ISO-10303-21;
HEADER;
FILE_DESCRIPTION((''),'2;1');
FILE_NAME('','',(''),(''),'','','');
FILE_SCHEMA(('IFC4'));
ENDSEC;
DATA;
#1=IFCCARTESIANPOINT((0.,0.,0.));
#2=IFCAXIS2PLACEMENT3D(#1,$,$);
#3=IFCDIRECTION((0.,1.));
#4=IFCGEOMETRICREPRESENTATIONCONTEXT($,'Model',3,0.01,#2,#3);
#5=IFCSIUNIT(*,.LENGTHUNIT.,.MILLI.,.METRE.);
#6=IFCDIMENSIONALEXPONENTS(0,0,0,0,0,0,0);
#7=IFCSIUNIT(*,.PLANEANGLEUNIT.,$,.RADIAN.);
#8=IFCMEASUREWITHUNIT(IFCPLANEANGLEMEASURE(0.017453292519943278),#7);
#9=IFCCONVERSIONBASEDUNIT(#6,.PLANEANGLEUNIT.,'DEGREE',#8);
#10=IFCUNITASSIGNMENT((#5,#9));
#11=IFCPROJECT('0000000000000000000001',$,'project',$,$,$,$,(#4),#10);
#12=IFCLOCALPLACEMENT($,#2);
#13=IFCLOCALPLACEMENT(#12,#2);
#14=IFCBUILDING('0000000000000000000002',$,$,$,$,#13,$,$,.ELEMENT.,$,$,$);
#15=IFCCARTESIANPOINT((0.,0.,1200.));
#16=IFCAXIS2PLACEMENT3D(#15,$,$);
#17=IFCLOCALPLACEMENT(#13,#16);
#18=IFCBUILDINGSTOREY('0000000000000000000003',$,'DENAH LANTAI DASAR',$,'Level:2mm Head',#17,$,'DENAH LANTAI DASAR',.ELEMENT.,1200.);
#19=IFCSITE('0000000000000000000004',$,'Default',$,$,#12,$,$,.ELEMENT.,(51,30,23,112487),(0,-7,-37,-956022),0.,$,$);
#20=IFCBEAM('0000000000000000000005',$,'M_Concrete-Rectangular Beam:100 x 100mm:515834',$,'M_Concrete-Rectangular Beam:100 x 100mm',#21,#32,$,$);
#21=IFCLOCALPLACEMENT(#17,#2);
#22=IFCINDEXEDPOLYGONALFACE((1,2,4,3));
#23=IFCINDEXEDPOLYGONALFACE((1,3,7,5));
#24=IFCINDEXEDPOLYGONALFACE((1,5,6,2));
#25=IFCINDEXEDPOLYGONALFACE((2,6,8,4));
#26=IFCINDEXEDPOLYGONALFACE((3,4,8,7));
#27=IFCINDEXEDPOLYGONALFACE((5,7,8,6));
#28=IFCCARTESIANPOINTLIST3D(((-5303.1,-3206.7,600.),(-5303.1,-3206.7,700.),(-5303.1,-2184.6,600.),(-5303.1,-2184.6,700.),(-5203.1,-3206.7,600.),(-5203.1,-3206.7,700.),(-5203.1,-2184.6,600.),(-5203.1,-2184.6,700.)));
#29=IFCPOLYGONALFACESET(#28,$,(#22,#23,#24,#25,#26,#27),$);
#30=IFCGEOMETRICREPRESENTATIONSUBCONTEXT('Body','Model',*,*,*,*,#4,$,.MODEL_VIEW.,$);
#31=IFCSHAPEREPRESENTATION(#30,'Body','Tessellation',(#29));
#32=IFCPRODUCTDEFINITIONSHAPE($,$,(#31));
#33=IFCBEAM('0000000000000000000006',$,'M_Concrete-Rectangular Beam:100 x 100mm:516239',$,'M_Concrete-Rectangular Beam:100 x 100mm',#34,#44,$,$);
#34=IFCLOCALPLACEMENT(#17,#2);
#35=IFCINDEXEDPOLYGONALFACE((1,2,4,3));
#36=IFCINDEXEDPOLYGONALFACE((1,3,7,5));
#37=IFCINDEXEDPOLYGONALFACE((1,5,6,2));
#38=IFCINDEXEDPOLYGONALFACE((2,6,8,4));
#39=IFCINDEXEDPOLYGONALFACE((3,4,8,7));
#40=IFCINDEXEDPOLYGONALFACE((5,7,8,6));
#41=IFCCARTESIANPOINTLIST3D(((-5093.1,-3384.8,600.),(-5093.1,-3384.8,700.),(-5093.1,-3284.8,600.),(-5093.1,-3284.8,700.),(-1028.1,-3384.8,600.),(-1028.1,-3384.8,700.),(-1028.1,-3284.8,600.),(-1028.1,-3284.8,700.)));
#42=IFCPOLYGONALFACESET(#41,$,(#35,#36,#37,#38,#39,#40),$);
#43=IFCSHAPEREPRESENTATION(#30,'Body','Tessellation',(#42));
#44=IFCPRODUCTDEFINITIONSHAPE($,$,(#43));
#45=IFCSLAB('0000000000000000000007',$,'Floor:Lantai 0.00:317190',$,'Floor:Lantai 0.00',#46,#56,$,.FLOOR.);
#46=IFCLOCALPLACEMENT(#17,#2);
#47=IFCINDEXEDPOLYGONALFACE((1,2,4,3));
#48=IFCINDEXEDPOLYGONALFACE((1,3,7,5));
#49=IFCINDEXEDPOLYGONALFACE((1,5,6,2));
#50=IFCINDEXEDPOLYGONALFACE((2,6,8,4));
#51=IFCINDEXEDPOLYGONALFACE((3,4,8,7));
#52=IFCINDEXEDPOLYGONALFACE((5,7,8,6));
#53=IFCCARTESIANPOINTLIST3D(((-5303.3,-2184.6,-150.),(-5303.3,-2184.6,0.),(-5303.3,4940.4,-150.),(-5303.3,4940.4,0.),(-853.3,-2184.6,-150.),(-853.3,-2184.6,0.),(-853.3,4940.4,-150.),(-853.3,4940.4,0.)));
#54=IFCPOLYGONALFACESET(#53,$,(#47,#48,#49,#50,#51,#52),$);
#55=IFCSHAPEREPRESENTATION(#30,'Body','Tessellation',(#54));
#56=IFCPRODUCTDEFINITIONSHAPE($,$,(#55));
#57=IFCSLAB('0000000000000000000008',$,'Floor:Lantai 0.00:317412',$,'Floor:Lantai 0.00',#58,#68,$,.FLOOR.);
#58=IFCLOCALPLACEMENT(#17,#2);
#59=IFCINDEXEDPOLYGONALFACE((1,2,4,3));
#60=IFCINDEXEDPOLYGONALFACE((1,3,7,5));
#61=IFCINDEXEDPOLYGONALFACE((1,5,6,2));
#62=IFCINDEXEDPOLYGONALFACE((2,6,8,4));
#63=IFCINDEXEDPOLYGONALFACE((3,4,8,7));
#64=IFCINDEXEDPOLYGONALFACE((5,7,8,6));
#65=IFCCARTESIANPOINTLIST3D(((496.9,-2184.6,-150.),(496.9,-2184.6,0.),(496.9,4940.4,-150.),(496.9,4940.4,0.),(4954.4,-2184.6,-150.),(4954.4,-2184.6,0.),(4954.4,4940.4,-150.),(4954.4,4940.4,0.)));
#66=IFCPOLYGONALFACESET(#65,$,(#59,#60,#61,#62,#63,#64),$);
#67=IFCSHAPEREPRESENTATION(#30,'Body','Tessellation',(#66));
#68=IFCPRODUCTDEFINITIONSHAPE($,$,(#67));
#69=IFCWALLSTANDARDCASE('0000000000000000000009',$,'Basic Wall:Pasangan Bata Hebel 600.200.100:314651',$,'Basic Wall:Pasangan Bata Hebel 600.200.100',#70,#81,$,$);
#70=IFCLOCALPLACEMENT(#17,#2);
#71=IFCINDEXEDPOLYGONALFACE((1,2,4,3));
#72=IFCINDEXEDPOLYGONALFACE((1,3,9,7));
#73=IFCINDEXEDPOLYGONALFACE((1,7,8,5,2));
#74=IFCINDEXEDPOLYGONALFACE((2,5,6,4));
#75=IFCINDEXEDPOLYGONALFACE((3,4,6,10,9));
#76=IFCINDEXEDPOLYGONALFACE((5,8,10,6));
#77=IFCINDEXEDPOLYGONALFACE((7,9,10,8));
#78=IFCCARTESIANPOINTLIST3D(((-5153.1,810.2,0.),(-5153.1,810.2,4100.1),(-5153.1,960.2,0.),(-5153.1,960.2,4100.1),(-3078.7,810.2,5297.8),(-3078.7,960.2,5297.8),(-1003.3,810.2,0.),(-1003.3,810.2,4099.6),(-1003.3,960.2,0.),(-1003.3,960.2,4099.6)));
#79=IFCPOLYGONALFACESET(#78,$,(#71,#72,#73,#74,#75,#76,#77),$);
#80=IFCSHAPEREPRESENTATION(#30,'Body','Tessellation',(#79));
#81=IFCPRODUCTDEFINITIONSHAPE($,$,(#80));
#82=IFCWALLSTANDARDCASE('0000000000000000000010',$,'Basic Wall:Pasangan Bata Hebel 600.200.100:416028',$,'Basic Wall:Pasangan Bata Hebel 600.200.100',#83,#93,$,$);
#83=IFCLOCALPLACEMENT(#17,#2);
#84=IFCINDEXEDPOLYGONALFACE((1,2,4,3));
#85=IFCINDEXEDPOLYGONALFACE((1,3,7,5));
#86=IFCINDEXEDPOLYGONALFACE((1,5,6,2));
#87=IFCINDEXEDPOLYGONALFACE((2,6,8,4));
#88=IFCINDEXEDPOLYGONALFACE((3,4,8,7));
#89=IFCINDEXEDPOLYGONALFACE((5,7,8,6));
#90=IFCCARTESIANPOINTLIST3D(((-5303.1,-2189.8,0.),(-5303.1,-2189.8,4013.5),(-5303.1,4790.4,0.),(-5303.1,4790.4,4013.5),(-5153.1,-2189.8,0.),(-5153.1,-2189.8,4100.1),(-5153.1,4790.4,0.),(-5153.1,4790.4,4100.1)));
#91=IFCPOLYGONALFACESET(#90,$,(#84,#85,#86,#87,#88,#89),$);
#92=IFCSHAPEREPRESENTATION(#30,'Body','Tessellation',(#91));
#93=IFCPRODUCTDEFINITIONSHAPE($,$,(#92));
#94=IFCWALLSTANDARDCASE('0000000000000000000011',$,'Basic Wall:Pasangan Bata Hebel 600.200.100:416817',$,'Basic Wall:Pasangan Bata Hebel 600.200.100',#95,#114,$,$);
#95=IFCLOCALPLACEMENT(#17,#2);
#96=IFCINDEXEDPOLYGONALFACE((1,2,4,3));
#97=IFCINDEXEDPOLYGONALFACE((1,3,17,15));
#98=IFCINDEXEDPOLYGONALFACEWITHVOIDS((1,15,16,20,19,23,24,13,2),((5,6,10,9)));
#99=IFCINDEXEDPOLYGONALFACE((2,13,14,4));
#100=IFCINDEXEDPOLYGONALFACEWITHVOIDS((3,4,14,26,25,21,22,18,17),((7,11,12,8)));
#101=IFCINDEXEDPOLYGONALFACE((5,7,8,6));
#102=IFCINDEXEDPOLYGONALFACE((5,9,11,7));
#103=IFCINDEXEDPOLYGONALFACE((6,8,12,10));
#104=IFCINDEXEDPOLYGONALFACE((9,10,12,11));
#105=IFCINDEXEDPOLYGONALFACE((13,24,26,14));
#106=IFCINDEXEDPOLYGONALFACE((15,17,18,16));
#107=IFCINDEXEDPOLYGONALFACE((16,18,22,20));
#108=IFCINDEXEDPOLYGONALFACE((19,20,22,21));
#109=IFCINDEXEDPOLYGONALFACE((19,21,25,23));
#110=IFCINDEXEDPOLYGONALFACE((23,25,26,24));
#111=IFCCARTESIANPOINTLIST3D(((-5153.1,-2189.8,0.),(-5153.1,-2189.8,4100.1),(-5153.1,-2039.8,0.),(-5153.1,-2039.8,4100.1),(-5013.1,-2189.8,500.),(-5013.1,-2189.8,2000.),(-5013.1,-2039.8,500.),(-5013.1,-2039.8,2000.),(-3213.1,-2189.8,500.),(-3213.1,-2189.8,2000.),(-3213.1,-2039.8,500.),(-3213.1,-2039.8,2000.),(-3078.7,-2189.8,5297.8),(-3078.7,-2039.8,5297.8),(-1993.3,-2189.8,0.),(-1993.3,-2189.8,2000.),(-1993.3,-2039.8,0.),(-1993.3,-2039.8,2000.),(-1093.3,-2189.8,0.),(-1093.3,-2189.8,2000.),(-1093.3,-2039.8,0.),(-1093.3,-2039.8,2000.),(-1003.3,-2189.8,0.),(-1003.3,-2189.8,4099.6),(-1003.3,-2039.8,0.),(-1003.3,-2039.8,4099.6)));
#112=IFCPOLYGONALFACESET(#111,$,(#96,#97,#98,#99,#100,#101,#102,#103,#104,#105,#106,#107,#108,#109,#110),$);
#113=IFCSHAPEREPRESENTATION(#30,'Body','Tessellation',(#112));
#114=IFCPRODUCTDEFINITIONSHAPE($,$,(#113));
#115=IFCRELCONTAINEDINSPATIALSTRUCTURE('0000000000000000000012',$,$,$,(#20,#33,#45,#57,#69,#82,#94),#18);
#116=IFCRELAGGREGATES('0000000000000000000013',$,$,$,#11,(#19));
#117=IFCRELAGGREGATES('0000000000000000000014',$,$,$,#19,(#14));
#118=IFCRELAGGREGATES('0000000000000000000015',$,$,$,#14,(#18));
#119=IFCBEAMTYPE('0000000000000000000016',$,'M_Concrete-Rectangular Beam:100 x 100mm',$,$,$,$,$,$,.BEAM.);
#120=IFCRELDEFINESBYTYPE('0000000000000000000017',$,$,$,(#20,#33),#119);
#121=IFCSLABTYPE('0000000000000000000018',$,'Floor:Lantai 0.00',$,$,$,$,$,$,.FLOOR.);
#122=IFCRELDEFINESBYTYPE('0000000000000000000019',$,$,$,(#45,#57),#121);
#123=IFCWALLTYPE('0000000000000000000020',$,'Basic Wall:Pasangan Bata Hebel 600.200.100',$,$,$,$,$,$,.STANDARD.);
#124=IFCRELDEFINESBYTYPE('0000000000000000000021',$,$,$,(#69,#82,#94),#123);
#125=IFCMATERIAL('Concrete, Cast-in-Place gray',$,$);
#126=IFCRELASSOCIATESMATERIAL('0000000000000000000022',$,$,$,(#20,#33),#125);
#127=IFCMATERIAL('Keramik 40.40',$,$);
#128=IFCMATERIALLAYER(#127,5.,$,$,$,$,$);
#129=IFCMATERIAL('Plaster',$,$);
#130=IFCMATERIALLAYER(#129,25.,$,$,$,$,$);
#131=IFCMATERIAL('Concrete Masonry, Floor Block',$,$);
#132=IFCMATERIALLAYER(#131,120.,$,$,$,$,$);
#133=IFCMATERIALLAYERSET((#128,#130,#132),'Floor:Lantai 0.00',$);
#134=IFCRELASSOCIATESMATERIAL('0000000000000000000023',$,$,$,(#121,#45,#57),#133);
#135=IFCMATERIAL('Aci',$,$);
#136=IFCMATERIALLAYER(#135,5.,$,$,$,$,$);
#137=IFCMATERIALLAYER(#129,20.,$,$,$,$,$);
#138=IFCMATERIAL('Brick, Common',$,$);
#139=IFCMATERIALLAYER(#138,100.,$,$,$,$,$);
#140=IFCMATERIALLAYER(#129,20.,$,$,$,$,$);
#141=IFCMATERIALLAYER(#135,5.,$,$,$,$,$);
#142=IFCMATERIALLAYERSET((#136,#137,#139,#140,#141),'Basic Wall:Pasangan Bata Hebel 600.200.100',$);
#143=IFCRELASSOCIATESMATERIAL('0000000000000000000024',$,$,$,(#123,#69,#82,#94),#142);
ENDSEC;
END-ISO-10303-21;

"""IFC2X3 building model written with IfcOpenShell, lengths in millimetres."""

from ifc_helpers import new_model, entity, si_unit, converted_unit, direction, frame, frame_2d, origin, origin_2d_with_axis, place, context, subcontext, project, spatial, polyline, rectangle, extrude, clip, bounded_halfspace, material, layer, layer_set, layer_usage, type_object, element, save


model = new_model("IFC2X3")

# Units and contexts
model_context = context("Model", 3, precision=0.01, world=origin(), true_north=direction((0.0, 1.0)))
body_context = subcontext(model_context, "Body", "Model", "MODEL_VIEW")
ifc_project = project(units=[si_unit("LENGTHUNIT", "METRE", prefix="MILLI"), converted_unit("PLANEANGLEUNIT", "DEGREE", entity("IfcPlaneAngleMeasure", 0.017453292519943278), si_unit("PLANEANGLEUNIT", "RADIAN"), dimensions=[0, 0, 0, 0, 0, 0, 0])], contexts=[model_context])

# Site, building, storey
site_placement = place(None, origin())
site = spatial("IfcSite", under=ifc_project, at=site_placement, Name="Default", CompositionType="ELEMENT", RefLatitude=(51, 30, 23, 112487), RefLongitude=(0, -7, -37, -956022), RefElevation=0.0)
building_placement = place(site_placement, origin())
building = spatial("IfcBuilding", under=site, at=building_placement, CompositionType="ELEMENT")
storey_placement = place(building_placement, frame((0.0, 0.0, 1200.0)))
storey = spatial("IfcBuildingStorey", under=building, at=storey_placement, Name="DENAH LANTAI DASAR", ObjectType="Level:2mm Head", LongName="DENAH LANTAI DASAR", CompositionType="ELEMENT", Elevation=1200.0)

# Shared definitions
ifc_material_1 = material(Name="Concrete, Cast-in-Place gray")

# Beams
beam_type = type_object("IfcBeamType", Name="M_Concrete-Rectangular Beam:100 x 100mm", PredefinedType="BEAM")
beam_1_placement = place(storey_placement, frame((-5253.1, -2184.6, 700.0), z_axis=(0.0, 0.0, 1.0), x_axis=(0.0, -1.0, 0.0)))
element("IfcBeam", 1, at=beam_1_placement, inside=storey, type_object=beam_type, material=ifc_material_1, Name="M_Concrete-Rectangular Beam:100 x 100mm:515834", ObjectType="M_Concrete-Rectangular Beam:100 x 100mm", context=body_context, shape_type="SweptSolid", body=[
    extrude(rectangle(XDim=100.0, YDim=100.0, at=frame_2d((0.0, 0.0), x_axis=(1.0, 0.0))), frame((0.0, 0.0, -50.0), z_axis=(1.0, 0.0, 0.0), x_axis=(0.0, 0.0, -1.0)), (0.0, 0.0, 1.0), 1022.1),
])
beam_2_placement = place(storey_placement, frame((-5093.1, -3334.8, 700.0)))
element("IfcBeam", 2, at=beam_2_placement, inside=storey, type_object=beam_type, material=ifc_material_1, Name="M_Concrete-Rectangular Beam:100 x 100mm:516239", ObjectType="M_Concrete-Rectangular Beam:100 x 100mm", context=body_context, shape_type="SweptSolid", body=[
    extrude(rectangle(XDim=100.0, YDim=100.0, at=origin_2d_with_axis()), frame((0.0, 0.0, -50.0), z_axis=(1.0, 0.0, 0.0), x_axis=(0.0, 0.0, -1.0)), (0.0, 0.0, 1.0), 4065.0),
])

# Slabs
ifc_material_2 = material(Name="Keramik 40.40")
ifc_layer_1 = layer(ifc_material_2, 5.0)
ifc_material_3 = material(Name="Plaster")
ifc_layer_2 = layer(ifc_material_3, 25.0)
ifc_material_4 = material(Name="Concrete Masonry, Floor Block")
ifc_layer_3 = layer(ifc_material_4, 120.0)
ifc_layer_set_1 = layer_set([ifc_layer_1, ifc_layer_2, ifc_layer_3], Name="Floor:Lantai 0.00")
ifc_layer_usage_1 = layer_usage(ifc_layer_set_1, "AXIS3", "POSITIVE", 0.0)
slab_type_1 = type_object("IfcSlabType", Name="Floor:Lantai 0.00", PredefinedType="FLOOR", material=ifc_layer_set_1)
slab_1_placement = place(storey_placement, origin())
element("IfcSlab", 3, at=slab_1_placement, inside=storey, type_object=slab_type_1, material=ifc_layer_usage_1, Name="Floor:Lantai 0.00:317190", ObjectType="Floor:Lantai 0.00", PredefinedType="FLOOR", context=body_context, shape_type="SweptSolid", body=[
    extrude(rectangle(XDim=7125.0, YDim=4450.0, at=origin_2d_with_axis()), frame((-3078.3, 1377.9, 0.0), z_axis=(0.0, 0.0, -1.0), x_axis=(0.0, 1.0, 0.0)), (0.0, 0.0, 1.0), 150.0),
])
ifc_layer_usage_2 = layer_usage(ifc_layer_set_1, "AXIS3", "POSITIVE", 0.0)
slab_2_placement = place(storey_placement, origin())
element("IfcSlab", 4, at=slab_2_placement, inside=storey, type_object=slab_type_1, material=ifc_layer_usage_2, Name="Floor:Lantai 0.00:317412", ObjectType="Floor:Lantai 0.00", PredefinedType="FLOOR", context=body_context, shape_type="SweptSolid", body=[
    extrude(rectangle(XDim=7125.0, YDim=4457.5, at=frame_2d((0.0, 0.0), x_axis=(1.0, 0.0))), frame((2725.7, 1377.9, 0.0), z_axis=(0.0, 0.0, -1.0), x_axis=(0.0, 1.0, 0.0)), (0.0, 0.0, 1.0), 150.0),
])

# Walls
ifc_material_5 = material(Name="Aci")
ifc_layer_4 = layer(ifc_material_5, 5.0)
ifc_layer_5 = layer(ifc_material_3, 20.0)
ifc_material_6 = material(Name="Brick, Common")
ifc_layer_6 = layer(ifc_material_6, 100.0)
ifc_layer_7 = layer(ifc_material_3, 20.0)
ifc_layer_8 = layer(ifc_material_5, 5.0)
ifc_layer_set_2 = layer_set([ifc_layer_4, ifc_layer_5, ifc_layer_6, ifc_layer_7, ifc_layer_8], Name="Basic Wall:Pasangan Bata Hebel 600.200.100")
ifc_layer_usage_3 = layer_usage(ifc_layer_set_2, "AXIS2", "NEGATIVE", 75.0)
wall_type = type_object("IfcWallType", Name="Basic Wall:Pasangan Bata Hebel 600.200.100", PredefinedType="STANDARD", material=ifc_layer_set_2)
wall_1_placement = place(storey_placement, frame((-1003.3, 885.2, 0.0), z_axis=(0.0, 0.0, 1.0), x_axis=(-1.0, 0.0, 0.0)))
element("IfcWallStandardCase", 5, at=wall_1_placement, inside=storey, type_object=wall_type, material=ifc_layer_usage_3, Name="Basic Wall:Pasangan Bata Hebel 600.200.100:314651", ObjectType="Basic Wall:Pasangan Bata Hebel 600.200.100", context=body_context, shape_type="Clipping", body=[
    clip(clip(extrude(rectangle(XDim=4149.8, YDim=150.0, at=frame_2d((2074.9, 0.0), x_axis=(-1.0, 0.0))), origin(), (0.0, 0.0, 1.0), 5297.8), bounded_halfspace(frame((2075.4, -75.0, 5297.8), z_axis=(0.5, 0.0, 0.866025), x_axis=(0.0, 1.0, 0.0)), False, frame((2075.4, -75.0, 5297.8)), polyline([(0.0, 0.0), (2074.4, 0.0), (2074.4, 150.0), (0.0, 150.0), (0.0, 0.0)]))), bounded_halfspace(frame((0.0, -75.0, 4099.6), z_axis=(-0.5, 0.0, 0.866025), x_axis=(0.0, -1.0, 0.0)), False, frame((0.0, -75.0, 4099.6)), polyline([(0.0, 0.0), (2075.4, 0.0), (2075.4, 150.0), (0.0, 150.0), (0.0, 0.0)]))),
])
ifc_layer_usage_4 = layer_usage(ifc_layer_set_2, "AXIS2", "NEGATIVE", 75.0)
wall_2_placement = place(storey_placement, frame((-5228.1, -2189.8, 0.0), z_axis=(0.0, 0.0, 1.0), x_axis=(0.0, 1.0, 0.0)))
element("IfcWallStandardCase", 6, at=wall_2_placement, inside=storey, type_object=wall_type, material=ifc_layer_usage_4, Name="Basic Wall:Pasangan Bata Hebel 600.200.100:416028", ObjectType="Basic Wall:Pasangan Bata Hebel 600.200.100", context=body_context, shape_type="Clipping", body=[
    clip(extrude(rectangle(XDim=6980.2, YDim=150.0, at=frame_2d((3490.1, 0.0), x_axis=(-1.0, 0.0))), origin(), (0.0, 0.0, 1.0), 4100.1), bounded_halfspace(frame((0.0, -75.0, 4100.1), z_axis=(0.0, 0.5, 0.866025), x_axis=(-1.0, 0.0, 0.0)), False, frame((0.0, -75.0, 4100.1)), polyline([(0.0, 0.0), (150.0, 0.0), (3000.0, 0.0), (3150.0, 0.0), (6980.2, 0.0), (6980.2, 150.0), (0.0, 150.0), (0.0, 0.0)]))),
])

# Wall, openings
ifc_layer_usage_5 = layer_usage(ifc_layer_set_2, "AXIS2", "NEGATIVE", 75.0)
wall_3_placement = place(storey_placement, frame((-5153.1, -2114.8, 0.0)))
wall_3 = element("IfcWallStandardCase", 7, at=wall_3_placement, inside=storey, type_object=wall_type, material=ifc_layer_usage_5, Name="Basic Wall:Pasangan Bata Hebel 600.200.100:416817", ObjectType="Basic Wall:Pasangan Bata Hebel 600.200.100", context=body_context, shape_type="Clipping", body=[
    clip(clip(extrude(rectangle(XDim=4149.8, YDim=150.0, at=frame_2d((2074.9, 0.0), x_axis=(-1.0, 0.0))), origin(), (0.0, 0.0, 1.0), 5297.8), bounded_halfspace(frame((0.0, -75.0, 4100.1), z_axis=(-0.5, 0.0, 0.866025), x_axis=(0.0, -1.0, 0.0)), False, frame((0.0, -75.0, 4100.1)), polyline([(0.0, 0.0), (2074.4, 0.0), (2074.4, 150.0), (0.0, 150.0), (0.0, 0.0)]))), bounded_halfspace(frame((2074.4, -75.0, 5297.8), z_axis=(0.5, 0.0, 0.866025), x_axis=(0.0, 1.0, 0.0)), False, frame((2074.4, -75.0, 5297.8)), polyline([(0.0, 0.0), (2075.4, 0.0), (2075.4, 150.0), (0.0, 150.0), (0.0, 0.0)]))),
])
opening_1_placement = place(wall_3_placement, frame((3159.8, -75.0, 0.0)))
element("IfcOpeningElement", 8, at=opening_1_placement, cuts=wall_3, ObjectType="Opening", context=body_context, shape_type="SweptSolid", body=[
    extrude(rectangle(XDim=2000.0, YDim=900.0, at=frame_2d((1000.0, 450.0), x_axis=(1.0, 0.0))), frame((0.0, 0.0, 0.0), z_axis=(0.0, 1.0, 0.0), x_axis=(0.0, 0.0, 1.0)), (0.0, 0.0, 1.0), 150.0),
])
opening_2_placement = place(wall_3_placement, frame((5153.1, 2114.8, 0.0)))
element("IfcOpeningElement", 9, at=opening_2_placement, cuts=wall_3, ObjectType="Opening", context=body_context, shape_type="SweptSolid", body=[
    extrude(rectangle(XDim=1500.0, YDim=1800.0, at=origin_2d_with_axis()), frame((-4113.1, -2189.8, 1250.0), z_axis=(0.0, 1.0, 0.0), x_axis=(0.0, 0.0, -1.0)), (0.0, 0.0, 1.0), 150.0),
])

save(model, "model.ifc")
